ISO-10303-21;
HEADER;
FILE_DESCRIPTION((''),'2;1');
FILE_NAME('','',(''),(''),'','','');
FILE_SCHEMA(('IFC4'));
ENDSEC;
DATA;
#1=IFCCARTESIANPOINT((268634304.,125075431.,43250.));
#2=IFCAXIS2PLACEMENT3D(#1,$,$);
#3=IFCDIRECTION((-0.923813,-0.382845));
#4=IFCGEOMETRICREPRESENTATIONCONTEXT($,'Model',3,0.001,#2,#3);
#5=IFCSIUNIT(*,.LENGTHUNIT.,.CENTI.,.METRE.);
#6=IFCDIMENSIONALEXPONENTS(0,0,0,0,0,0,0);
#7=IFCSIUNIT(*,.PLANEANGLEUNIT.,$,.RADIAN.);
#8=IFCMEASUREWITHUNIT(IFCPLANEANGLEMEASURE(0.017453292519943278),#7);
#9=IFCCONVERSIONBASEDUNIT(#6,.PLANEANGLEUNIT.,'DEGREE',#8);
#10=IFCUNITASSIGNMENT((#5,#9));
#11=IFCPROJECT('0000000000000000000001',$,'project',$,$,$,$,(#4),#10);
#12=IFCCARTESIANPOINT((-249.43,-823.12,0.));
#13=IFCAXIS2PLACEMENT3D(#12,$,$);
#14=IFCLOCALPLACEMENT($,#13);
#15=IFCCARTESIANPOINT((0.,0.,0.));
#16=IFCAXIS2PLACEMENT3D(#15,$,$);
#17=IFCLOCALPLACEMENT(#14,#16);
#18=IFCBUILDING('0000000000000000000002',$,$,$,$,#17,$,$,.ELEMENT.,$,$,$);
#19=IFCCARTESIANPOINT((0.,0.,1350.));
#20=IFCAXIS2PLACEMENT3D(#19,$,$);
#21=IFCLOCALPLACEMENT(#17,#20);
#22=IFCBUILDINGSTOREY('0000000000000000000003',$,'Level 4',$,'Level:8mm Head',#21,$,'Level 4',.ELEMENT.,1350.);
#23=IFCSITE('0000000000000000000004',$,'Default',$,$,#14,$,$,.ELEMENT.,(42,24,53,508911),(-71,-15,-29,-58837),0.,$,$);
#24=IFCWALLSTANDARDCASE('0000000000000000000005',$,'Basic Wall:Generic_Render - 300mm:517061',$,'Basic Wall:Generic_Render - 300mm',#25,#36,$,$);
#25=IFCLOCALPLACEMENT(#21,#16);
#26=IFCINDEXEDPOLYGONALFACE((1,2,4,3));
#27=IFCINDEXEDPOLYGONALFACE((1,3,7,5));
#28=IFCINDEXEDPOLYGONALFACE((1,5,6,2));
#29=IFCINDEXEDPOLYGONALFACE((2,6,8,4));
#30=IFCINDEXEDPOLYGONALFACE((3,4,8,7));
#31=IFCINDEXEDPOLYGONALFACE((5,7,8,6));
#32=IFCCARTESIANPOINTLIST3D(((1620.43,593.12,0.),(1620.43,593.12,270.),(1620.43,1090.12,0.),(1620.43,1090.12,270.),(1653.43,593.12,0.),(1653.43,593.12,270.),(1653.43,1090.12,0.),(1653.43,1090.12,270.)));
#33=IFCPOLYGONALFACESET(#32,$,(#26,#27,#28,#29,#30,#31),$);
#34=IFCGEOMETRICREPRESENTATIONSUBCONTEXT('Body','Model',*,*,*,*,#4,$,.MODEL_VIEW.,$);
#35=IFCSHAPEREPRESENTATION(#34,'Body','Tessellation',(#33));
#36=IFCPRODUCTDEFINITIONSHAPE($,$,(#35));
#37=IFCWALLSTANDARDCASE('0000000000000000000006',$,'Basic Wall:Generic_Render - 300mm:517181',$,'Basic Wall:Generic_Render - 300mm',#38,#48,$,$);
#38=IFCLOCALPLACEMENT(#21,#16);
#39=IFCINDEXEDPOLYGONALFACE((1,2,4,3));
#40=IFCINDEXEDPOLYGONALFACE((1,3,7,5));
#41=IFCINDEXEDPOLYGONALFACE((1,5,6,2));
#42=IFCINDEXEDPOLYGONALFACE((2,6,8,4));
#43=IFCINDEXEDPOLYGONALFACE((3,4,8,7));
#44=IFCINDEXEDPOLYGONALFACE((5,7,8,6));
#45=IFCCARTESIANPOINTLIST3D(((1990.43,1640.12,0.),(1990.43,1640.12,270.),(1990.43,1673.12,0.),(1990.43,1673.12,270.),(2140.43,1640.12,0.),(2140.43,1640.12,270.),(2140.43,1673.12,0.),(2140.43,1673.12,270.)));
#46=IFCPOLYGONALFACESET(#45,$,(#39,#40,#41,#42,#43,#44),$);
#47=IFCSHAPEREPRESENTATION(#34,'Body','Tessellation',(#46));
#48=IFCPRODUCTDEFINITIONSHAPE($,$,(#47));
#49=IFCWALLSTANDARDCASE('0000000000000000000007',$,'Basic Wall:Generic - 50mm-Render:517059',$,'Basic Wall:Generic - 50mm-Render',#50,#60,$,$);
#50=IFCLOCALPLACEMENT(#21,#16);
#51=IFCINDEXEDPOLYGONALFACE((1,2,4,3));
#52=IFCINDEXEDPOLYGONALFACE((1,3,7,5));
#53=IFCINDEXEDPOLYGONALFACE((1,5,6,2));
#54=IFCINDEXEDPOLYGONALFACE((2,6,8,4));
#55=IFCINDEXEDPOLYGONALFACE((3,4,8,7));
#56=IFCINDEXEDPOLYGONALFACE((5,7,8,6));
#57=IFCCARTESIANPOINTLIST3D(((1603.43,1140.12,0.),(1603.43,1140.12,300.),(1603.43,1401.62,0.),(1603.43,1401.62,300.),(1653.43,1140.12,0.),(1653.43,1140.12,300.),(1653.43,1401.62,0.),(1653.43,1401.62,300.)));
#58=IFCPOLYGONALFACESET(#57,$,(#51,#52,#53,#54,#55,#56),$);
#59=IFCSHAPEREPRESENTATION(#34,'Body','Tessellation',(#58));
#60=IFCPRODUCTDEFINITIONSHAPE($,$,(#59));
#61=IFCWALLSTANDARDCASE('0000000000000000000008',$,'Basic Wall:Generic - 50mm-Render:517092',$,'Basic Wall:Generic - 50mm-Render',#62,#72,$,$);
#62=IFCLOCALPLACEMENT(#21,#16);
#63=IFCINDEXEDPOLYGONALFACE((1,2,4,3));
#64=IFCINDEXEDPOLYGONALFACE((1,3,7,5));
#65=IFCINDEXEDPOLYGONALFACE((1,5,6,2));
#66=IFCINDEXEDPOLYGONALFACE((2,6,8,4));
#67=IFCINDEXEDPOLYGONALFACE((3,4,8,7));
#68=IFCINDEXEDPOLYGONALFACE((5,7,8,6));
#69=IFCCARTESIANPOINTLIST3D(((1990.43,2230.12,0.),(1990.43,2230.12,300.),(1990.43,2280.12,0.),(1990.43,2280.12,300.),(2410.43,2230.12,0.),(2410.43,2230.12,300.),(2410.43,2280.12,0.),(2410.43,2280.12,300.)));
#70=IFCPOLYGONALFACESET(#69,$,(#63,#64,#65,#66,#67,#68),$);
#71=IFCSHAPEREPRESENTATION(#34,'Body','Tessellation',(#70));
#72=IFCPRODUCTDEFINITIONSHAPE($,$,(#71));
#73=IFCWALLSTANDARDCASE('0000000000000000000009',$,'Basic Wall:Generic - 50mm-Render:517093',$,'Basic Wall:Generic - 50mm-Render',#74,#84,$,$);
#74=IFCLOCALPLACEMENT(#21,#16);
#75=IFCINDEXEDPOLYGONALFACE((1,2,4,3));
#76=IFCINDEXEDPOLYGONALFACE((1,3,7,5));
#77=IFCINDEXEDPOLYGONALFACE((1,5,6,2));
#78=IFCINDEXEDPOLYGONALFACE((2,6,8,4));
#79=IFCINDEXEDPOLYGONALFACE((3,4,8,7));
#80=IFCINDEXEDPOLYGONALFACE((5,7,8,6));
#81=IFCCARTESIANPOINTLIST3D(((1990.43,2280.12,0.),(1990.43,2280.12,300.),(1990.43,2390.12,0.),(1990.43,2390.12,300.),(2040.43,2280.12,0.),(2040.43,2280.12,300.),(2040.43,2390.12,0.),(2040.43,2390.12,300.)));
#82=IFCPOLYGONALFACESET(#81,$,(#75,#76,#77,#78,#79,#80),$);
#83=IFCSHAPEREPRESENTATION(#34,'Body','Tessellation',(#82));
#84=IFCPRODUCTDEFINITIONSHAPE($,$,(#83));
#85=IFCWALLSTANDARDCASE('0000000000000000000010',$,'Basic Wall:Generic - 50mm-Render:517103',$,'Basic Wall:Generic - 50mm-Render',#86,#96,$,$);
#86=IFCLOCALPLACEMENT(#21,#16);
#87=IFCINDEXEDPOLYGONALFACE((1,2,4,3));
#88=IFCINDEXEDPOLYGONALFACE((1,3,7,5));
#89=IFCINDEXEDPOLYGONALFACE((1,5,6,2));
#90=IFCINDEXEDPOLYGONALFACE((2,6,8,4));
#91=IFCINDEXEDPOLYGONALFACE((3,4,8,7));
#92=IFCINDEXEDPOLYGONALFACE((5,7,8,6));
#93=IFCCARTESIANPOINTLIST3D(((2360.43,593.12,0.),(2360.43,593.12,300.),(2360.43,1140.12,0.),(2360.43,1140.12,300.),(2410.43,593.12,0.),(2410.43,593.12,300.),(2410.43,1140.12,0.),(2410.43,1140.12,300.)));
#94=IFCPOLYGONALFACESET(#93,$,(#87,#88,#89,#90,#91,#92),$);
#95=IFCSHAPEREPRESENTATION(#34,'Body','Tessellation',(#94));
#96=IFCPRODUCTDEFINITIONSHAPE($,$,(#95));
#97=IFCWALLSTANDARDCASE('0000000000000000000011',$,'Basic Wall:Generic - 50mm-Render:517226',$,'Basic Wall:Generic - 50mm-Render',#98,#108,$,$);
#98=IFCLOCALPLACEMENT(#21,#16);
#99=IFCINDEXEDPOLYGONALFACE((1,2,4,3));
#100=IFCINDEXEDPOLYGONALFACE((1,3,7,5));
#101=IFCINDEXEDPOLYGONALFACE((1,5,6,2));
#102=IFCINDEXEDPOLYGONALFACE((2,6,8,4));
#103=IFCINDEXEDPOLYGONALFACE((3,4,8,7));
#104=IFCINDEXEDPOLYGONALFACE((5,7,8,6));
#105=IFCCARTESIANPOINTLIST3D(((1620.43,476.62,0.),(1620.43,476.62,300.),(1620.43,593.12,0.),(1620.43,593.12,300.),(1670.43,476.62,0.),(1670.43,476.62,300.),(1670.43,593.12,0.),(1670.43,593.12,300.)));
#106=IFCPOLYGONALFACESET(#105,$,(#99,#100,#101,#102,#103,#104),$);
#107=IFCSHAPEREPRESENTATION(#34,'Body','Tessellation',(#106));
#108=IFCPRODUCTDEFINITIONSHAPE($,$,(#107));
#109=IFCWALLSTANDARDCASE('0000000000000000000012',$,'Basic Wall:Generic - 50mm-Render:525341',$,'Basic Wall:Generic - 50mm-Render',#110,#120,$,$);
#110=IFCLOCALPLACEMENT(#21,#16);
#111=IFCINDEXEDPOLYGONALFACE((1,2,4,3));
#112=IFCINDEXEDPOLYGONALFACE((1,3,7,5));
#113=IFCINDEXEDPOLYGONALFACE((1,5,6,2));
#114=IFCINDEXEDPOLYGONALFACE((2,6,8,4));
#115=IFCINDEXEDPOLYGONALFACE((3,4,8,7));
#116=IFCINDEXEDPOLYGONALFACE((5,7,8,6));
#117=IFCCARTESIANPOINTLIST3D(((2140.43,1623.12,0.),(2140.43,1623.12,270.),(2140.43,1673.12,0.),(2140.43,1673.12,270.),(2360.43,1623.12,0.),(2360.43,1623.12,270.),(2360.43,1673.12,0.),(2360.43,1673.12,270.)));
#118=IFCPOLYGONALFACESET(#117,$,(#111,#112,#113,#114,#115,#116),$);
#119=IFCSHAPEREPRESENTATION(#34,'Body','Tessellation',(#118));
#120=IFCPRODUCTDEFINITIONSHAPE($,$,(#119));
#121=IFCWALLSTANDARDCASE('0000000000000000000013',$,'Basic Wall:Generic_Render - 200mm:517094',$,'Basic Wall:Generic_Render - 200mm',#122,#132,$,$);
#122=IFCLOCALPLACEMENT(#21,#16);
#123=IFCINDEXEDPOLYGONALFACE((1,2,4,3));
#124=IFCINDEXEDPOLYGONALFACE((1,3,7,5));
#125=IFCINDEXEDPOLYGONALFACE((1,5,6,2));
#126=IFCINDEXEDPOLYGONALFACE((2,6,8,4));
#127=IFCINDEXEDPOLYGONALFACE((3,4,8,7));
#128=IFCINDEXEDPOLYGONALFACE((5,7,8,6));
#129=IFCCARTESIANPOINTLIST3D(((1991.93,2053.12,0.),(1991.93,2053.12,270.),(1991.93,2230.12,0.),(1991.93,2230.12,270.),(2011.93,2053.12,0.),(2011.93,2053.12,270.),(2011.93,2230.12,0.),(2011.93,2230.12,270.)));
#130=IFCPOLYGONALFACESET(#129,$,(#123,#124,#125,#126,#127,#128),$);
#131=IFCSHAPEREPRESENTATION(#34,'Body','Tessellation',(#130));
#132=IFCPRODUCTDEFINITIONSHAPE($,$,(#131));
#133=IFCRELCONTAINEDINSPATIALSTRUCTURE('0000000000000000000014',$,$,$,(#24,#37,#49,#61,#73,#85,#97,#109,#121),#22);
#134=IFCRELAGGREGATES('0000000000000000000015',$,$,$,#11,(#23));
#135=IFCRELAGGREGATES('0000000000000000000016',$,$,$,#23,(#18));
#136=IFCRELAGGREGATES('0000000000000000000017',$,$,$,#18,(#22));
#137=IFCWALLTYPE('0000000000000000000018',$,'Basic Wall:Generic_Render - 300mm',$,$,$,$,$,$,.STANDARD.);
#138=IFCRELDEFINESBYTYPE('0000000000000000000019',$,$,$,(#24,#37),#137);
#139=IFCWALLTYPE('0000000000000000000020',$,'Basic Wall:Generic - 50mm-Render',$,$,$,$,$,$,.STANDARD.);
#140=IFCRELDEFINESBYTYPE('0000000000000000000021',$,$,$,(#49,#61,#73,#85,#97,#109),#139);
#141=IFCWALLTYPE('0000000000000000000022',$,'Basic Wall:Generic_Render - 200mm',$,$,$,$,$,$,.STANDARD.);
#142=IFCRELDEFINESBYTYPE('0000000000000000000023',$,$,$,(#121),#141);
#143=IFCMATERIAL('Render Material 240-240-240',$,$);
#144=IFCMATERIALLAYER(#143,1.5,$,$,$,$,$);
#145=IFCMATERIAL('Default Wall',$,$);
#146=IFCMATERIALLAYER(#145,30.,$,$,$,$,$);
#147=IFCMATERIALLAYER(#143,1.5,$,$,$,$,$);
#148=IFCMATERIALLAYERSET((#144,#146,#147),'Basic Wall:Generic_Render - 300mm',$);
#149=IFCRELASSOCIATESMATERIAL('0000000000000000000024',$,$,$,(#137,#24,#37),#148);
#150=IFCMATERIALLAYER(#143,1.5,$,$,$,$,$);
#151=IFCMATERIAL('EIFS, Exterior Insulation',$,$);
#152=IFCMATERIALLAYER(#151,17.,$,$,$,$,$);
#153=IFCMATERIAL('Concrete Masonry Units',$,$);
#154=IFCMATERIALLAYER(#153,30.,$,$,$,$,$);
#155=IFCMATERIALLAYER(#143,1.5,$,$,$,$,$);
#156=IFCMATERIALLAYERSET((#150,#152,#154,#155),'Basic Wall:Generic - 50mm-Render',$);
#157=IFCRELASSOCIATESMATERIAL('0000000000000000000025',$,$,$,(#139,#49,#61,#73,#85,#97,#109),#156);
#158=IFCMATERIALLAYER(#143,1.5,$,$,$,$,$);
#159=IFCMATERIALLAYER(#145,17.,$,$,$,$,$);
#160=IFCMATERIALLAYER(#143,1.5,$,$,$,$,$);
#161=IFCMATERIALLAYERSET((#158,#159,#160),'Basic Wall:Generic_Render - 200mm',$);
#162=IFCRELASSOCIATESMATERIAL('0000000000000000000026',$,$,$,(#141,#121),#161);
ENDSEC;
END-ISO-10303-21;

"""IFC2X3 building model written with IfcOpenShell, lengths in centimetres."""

from ifc_helpers import new_model, entity, si_unit, converted_unit, direction, frame, frame_2d, origin, place, context, subcontext, project, spatial, rectangle, extrude, material, layer, layer_set, layer_usage, type_object, element, save


model = new_model("IFC2X3")

# Units and contexts
model_context = context("Model", 3, precision=0.001, world=frame((268634304.0, 125075431.0, 43250.0)), true_north=direction((-0.923813, -0.382845)))
body_context = subcontext(model_context, "Body", "Model", "MODEL_VIEW")
ifc_project = project(units=[si_unit("LENGTHUNIT", "METRE", prefix="CENTI"), converted_unit("PLANEANGLEUNIT", "DEGREE", entity("IfcPlaneAngleMeasure", 0.017453292519943278), si_unit("PLANEANGLEUNIT", "RADIAN"), dimensions=[0, 0, 0, 0, 0, 0, 0])], contexts=[model_context])

# Site, building, storey
site_placement = place(None, frame((-249.43, -823.12, 0.0)))
site = spatial("IfcSite", under=ifc_project, at=site_placement, Name="Default", CompositionType="ELEMENT", RefLatitude=(42, 24, 53, 508911), RefLongitude=(-71, -15, -29, -58837), RefElevation=0.0)
building_placement = place(site_placement, origin())
building = spatial("IfcBuilding", under=site, at=building_placement, CompositionType="ELEMENT")
storey_placement = place(building_placement, frame((0.0, 0.0, 1350.0)))
storey = spatial("IfcBuildingStorey", under=building, at=storey_placement, Name="Level 4", ObjectType="Level:8mm Head", LongName="Level 4", CompositionType="ELEMENT", Elevation=1350.0)

# Walls
ifc_material_1 = material(Name="Render Material 240-240-240")
ifc_layer_1 = layer(ifc_material_1, 1.5)
ifc_material_2 = material(Name="Default Wall")
ifc_layer_2 = layer(ifc_material_2, 30.0)
ifc_layer_3 = layer(ifc_material_1, 1.5)
ifc_layer_set_1 = layer_set([ifc_layer_1, ifc_layer_2, ifc_layer_3], Name="Basic Wall:Generic_Render - 300mm")
ifc_layer_usage_1 = layer_usage(ifc_layer_set_1, "AXIS2", "NEGATIVE", 16.5)
wall_type_1 = type_object("IfcWallType", Name="Basic Wall:Generic_Render - 300mm", PredefinedType="STANDARD", material=ifc_layer_set_1)
wall_1_placement = place(storey_placement, frame((1636.93, 1090.12, 0.0), z_axis=(0.0, 0.0, 1.0), x_axis=(0.0, -1.0, 0.0)))
element("IfcWallStandardCase", 1, at=wall_1_placement, inside=storey, type_object=wall_type_1, material=ifc_layer_usage_1, Name="Basic Wall:Generic_Render - 300mm:517061", ObjectType="Basic Wall:Generic_Render - 300mm", context=body_context, shape_type="SweptSolid", body=[
    extrude(rectangle(XDim=497.0, YDim=33.0, at=frame_2d((248.5, 0.0), x_axis=(-1.0, 0.0))), origin(), (0.0, 0.0, 1.0), 270.0),
])
ifc_layer_usage_2 = layer_usage(ifc_layer_set_1, "AXIS2", "NEGATIVE", 16.5)
wall_2_placement = place(storey_placement, frame((1990.43, 1656.62, 0.0)))
element("IfcWallStandardCase", 2, at=wall_2_placement, inside=storey, type_object=wall_type_1, material=ifc_layer_usage_2, Name="Basic Wall:Generic_Render - 300mm:517181", ObjectType="Basic Wall:Generic_Render - 300mm", context=body_context, shape_type="SweptSolid", body=[
    extrude(rectangle(XDim=150.0, YDim=33.0, at=frame_2d((75.0, 0.0), x_axis=(-1.0, 0.0))), origin(), (0.0, 0.0, 1.0), 270.0),
])
ifc_layer_4 = layer(ifc_material_1, 1.5)
ifc_material_3 = material(Name="EIFS, Exterior Insulation")
ifc_layer_5 = layer(ifc_material_3, 17.0)
ifc_material_4 = material(Name="Concrete Masonry Units")
ifc_layer_6 = layer(ifc_material_4, 30.0)
ifc_layer_7 = layer(ifc_material_1, 1.5)
ifc_layer_set_2 = layer_set([ifc_layer_4, ifc_layer_5, ifc_layer_6, ifc_layer_7], Name="Basic Wall:Generic - 50mm-Render")
ifc_layer_usage_3 = layer_usage(ifc_layer_set_2, "AXIS2", "POSITIVE", -25.0)
wall_type_2 = type_object("IfcWallType", Name="Basic Wall:Generic - 50mm-Render", PredefinedType="STANDARD", material=ifc_layer_set_2)
wall_3_placement = place(storey_placement, frame((1628.43, 1401.62, 0.0), z_axis=(0.0, 0.0, 1.0), x_axis=(0.0, -1.0, 0.0)))
element("IfcWallStandardCase", 3, at=wall_3_placement, inside=storey, type_object=wall_type_2, material=ifc_layer_usage_3, Name="Basic Wall:Generic - 50mm-Render:517059", ObjectType="Basic Wall:Generic - 50mm-Render", context=body_context, shape_type="SweptSolid", body=[
    extrude(rectangle(XDim=261.5, YDim=50.0, at=frame_2d((130.75, 0.0), x_axis=(-1.0, 0.0))), origin(), (0.0, 0.0, 1.0), 300.0),
])
ifc_layer_usage_4 = layer_usage(ifc_layer_set_2, "AXIS2", "NEGATIVE", 25.0)
wall_4_placement = place(storey_placement, frame((1990.43, 2255.12, 0.0)))
element("IfcWallStandardCase", 4, at=wall_4_placement, inside=storey, type_object=wall_type_2, material=ifc_layer_usage_4, Name="Basic Wall:Generic - 50mm-Render:517092", ObjectType="Basic Wall:Generic - 50mm-Render", context=body_context, shape_type="SweptSolid", body=[
    extrude(rectangle(XDim=420.0, YDim=50.0, at=frame_2d((210.0, 0.0), x_axis=(-1.0, 0.0))), origin(), (0.0, 0.0, 1.0), 300.0),
])
ifc_layer_usage_5 = layer_usage(ifc_layer_set_2, "AXIS2", "POSITIVE", -25.0)
wall_5_placement = place(storey_placement, frame((2015.43, 2280.12, 0.0), z_axis=(0.0, 0.0, 1.0), x_axis=(0.0, 1.0, 0.0)))
element("IfcWallStandardCase", 5, at=wall_5_placement, inside=storey, type_object=wall_type_2, material=ifc_layer_usage_5, Name="Basic Wall:Generic - 50mm-Render:517093", ObjectType="Basic Wall:Generic - 50mm-Render", context=body_context, shape_type="SweptSolid", body=[
    extrude(rectangle(XDim=110.0, YDim=50.0, at=frame_2d((55.0, 0.0), x_axis=(-1.0, 0.0))), origin(), (0.0, 0.0, 1.0), 300.0),
])
ifc_layer_usage_6 = layer_usage(ifc_layer_set_2, "AXIS2", "POSITIVE", -25.0)
wall_6_placement = place(storey_placement, frame((2385.43, 593.12, 0.0), z_axis=(0.0, 0.0, 1.0), x_axis=(0.0, 1.0, 0.0)))
element("IfcWallStandardCase", 6, at=wall_6_placement, inside=storey, type_object=wall_type_2, material=ifc_layer_usage_6, Name="Basic Wall:Generic - 50mm-Render:517103", ObjectType="Basic Wall:Generic - 50mm-Render", context=body_context, shape_type="SweptSolid", body=[
    extrude(rectangle(XDim=547.0, YDim=50.0, at=frame_2d((273.5, 0.0), x_axis=(-1.0, 0.0))), origin(), (0.0, 0.0, 1.0), 300.0),
])
ifc_layer_usage_7 = layer_usage(ifc_layer_set_2, "AXIS2", "NEGATIVE", 25.0)
wall_7_placement = place(storey_placement, frame((1645.43, 593.12, 0.0), z_axis=(0.0, 0.0, 1.0), x_axis=(0.0, -1.0, 0.0)))
element("IfcWallStandardCase", 7, at=wall_7_placement, inside=storey, type_object=wall_type_2, material=ifc_layer_usage_7, Name="Basic Wall:Generic - 50mm-Render:517226", ObjectType="Basic Wall:Generic - 50mm-Render", context=body_context, shape_type="SweptSolid", body=[
    extrude(rectangle(XDim=116.5, YDim=50.0, at=frame_2d((58.25, 0.0), x_axis=(-1.0, 0.0))), origin(), (0.0, 0.0, 1.0), 300.0),
])
ifc_layer_usage_8 = layer_usage(ifc_layer_set_2, "AXIS2", "POSITIVE", -25.0)
wall_8_placement = place(storey_placement, frame((2140.43, 1648.12, 0.0)))
element("IfcWallStandardCase", 8, at=wall_8_placement, inside=storey, type_object=wall_type_2, material=ifc_layer_usage_8, Name="Basic Wall:Generic - 50mm-Render:525341", ObjectType="Basic Wall:Generic - 50mm-Render", context=body_context, shape_type="SweptSolid", body=[
    extrude(rectangle(XDim=220.0, YDim=50.0, at=frame_2d((110.0, 0.0), x_axis=(-1.0, 0.0))), origin(), (0.0, 0.0, 1.0), 270.0),
])
ifc_layer_8 = layer(ifc_material_1, 1.5)
ifc_layer_9 = layer(ifc_material_2, 17.0)
ifc_layer_10 = layer(ifc_material_1, 1.5)
ifc_layer_set_3 = layer_set([ifc_layer_8, ifc_layer_9, ifc_layer_10], Name="Basic Wall:Generic_Render - 200mm")
ifc_layer_usage_9 = layer_usage(ifc_layer_set_3, "AXIS2", "NEGATIVE", 10.0)
wall_type_3 = type_object("IfcWallType", Name="Basic Wall:Generic_Render - 200mm", PredefinedType="STANDARD", material=ifc_layer_set_3)
wall_9_placement = place(storey_placement, frame((2001.93, 2230.12, 0.0), z_axis=(0.0, 0.0, 1.0), x_axis=(0.0, -1.0, 0.0)))
element("IfcWallStandardCase", 9, at=wall_9_placement, inside=storey, type_object=wall_type_3, material=ifc_layer_usage_9, Name="Basic Wall:Generic_Render - 200mm:517094", ObjectType="Basic Wall:Generic_Render - 200mm", context=body_context, shape_type="SweptSolid", body=[
    extrude(rectangle(XDim=177.0, YDim=20.0, at=frame_2d((88.5, 0.0), x_axis=(-1.0, 0.0))), origin(), (0.0, 0.0, 1.0), 270.0),
])

save(model, "model.ifc")
